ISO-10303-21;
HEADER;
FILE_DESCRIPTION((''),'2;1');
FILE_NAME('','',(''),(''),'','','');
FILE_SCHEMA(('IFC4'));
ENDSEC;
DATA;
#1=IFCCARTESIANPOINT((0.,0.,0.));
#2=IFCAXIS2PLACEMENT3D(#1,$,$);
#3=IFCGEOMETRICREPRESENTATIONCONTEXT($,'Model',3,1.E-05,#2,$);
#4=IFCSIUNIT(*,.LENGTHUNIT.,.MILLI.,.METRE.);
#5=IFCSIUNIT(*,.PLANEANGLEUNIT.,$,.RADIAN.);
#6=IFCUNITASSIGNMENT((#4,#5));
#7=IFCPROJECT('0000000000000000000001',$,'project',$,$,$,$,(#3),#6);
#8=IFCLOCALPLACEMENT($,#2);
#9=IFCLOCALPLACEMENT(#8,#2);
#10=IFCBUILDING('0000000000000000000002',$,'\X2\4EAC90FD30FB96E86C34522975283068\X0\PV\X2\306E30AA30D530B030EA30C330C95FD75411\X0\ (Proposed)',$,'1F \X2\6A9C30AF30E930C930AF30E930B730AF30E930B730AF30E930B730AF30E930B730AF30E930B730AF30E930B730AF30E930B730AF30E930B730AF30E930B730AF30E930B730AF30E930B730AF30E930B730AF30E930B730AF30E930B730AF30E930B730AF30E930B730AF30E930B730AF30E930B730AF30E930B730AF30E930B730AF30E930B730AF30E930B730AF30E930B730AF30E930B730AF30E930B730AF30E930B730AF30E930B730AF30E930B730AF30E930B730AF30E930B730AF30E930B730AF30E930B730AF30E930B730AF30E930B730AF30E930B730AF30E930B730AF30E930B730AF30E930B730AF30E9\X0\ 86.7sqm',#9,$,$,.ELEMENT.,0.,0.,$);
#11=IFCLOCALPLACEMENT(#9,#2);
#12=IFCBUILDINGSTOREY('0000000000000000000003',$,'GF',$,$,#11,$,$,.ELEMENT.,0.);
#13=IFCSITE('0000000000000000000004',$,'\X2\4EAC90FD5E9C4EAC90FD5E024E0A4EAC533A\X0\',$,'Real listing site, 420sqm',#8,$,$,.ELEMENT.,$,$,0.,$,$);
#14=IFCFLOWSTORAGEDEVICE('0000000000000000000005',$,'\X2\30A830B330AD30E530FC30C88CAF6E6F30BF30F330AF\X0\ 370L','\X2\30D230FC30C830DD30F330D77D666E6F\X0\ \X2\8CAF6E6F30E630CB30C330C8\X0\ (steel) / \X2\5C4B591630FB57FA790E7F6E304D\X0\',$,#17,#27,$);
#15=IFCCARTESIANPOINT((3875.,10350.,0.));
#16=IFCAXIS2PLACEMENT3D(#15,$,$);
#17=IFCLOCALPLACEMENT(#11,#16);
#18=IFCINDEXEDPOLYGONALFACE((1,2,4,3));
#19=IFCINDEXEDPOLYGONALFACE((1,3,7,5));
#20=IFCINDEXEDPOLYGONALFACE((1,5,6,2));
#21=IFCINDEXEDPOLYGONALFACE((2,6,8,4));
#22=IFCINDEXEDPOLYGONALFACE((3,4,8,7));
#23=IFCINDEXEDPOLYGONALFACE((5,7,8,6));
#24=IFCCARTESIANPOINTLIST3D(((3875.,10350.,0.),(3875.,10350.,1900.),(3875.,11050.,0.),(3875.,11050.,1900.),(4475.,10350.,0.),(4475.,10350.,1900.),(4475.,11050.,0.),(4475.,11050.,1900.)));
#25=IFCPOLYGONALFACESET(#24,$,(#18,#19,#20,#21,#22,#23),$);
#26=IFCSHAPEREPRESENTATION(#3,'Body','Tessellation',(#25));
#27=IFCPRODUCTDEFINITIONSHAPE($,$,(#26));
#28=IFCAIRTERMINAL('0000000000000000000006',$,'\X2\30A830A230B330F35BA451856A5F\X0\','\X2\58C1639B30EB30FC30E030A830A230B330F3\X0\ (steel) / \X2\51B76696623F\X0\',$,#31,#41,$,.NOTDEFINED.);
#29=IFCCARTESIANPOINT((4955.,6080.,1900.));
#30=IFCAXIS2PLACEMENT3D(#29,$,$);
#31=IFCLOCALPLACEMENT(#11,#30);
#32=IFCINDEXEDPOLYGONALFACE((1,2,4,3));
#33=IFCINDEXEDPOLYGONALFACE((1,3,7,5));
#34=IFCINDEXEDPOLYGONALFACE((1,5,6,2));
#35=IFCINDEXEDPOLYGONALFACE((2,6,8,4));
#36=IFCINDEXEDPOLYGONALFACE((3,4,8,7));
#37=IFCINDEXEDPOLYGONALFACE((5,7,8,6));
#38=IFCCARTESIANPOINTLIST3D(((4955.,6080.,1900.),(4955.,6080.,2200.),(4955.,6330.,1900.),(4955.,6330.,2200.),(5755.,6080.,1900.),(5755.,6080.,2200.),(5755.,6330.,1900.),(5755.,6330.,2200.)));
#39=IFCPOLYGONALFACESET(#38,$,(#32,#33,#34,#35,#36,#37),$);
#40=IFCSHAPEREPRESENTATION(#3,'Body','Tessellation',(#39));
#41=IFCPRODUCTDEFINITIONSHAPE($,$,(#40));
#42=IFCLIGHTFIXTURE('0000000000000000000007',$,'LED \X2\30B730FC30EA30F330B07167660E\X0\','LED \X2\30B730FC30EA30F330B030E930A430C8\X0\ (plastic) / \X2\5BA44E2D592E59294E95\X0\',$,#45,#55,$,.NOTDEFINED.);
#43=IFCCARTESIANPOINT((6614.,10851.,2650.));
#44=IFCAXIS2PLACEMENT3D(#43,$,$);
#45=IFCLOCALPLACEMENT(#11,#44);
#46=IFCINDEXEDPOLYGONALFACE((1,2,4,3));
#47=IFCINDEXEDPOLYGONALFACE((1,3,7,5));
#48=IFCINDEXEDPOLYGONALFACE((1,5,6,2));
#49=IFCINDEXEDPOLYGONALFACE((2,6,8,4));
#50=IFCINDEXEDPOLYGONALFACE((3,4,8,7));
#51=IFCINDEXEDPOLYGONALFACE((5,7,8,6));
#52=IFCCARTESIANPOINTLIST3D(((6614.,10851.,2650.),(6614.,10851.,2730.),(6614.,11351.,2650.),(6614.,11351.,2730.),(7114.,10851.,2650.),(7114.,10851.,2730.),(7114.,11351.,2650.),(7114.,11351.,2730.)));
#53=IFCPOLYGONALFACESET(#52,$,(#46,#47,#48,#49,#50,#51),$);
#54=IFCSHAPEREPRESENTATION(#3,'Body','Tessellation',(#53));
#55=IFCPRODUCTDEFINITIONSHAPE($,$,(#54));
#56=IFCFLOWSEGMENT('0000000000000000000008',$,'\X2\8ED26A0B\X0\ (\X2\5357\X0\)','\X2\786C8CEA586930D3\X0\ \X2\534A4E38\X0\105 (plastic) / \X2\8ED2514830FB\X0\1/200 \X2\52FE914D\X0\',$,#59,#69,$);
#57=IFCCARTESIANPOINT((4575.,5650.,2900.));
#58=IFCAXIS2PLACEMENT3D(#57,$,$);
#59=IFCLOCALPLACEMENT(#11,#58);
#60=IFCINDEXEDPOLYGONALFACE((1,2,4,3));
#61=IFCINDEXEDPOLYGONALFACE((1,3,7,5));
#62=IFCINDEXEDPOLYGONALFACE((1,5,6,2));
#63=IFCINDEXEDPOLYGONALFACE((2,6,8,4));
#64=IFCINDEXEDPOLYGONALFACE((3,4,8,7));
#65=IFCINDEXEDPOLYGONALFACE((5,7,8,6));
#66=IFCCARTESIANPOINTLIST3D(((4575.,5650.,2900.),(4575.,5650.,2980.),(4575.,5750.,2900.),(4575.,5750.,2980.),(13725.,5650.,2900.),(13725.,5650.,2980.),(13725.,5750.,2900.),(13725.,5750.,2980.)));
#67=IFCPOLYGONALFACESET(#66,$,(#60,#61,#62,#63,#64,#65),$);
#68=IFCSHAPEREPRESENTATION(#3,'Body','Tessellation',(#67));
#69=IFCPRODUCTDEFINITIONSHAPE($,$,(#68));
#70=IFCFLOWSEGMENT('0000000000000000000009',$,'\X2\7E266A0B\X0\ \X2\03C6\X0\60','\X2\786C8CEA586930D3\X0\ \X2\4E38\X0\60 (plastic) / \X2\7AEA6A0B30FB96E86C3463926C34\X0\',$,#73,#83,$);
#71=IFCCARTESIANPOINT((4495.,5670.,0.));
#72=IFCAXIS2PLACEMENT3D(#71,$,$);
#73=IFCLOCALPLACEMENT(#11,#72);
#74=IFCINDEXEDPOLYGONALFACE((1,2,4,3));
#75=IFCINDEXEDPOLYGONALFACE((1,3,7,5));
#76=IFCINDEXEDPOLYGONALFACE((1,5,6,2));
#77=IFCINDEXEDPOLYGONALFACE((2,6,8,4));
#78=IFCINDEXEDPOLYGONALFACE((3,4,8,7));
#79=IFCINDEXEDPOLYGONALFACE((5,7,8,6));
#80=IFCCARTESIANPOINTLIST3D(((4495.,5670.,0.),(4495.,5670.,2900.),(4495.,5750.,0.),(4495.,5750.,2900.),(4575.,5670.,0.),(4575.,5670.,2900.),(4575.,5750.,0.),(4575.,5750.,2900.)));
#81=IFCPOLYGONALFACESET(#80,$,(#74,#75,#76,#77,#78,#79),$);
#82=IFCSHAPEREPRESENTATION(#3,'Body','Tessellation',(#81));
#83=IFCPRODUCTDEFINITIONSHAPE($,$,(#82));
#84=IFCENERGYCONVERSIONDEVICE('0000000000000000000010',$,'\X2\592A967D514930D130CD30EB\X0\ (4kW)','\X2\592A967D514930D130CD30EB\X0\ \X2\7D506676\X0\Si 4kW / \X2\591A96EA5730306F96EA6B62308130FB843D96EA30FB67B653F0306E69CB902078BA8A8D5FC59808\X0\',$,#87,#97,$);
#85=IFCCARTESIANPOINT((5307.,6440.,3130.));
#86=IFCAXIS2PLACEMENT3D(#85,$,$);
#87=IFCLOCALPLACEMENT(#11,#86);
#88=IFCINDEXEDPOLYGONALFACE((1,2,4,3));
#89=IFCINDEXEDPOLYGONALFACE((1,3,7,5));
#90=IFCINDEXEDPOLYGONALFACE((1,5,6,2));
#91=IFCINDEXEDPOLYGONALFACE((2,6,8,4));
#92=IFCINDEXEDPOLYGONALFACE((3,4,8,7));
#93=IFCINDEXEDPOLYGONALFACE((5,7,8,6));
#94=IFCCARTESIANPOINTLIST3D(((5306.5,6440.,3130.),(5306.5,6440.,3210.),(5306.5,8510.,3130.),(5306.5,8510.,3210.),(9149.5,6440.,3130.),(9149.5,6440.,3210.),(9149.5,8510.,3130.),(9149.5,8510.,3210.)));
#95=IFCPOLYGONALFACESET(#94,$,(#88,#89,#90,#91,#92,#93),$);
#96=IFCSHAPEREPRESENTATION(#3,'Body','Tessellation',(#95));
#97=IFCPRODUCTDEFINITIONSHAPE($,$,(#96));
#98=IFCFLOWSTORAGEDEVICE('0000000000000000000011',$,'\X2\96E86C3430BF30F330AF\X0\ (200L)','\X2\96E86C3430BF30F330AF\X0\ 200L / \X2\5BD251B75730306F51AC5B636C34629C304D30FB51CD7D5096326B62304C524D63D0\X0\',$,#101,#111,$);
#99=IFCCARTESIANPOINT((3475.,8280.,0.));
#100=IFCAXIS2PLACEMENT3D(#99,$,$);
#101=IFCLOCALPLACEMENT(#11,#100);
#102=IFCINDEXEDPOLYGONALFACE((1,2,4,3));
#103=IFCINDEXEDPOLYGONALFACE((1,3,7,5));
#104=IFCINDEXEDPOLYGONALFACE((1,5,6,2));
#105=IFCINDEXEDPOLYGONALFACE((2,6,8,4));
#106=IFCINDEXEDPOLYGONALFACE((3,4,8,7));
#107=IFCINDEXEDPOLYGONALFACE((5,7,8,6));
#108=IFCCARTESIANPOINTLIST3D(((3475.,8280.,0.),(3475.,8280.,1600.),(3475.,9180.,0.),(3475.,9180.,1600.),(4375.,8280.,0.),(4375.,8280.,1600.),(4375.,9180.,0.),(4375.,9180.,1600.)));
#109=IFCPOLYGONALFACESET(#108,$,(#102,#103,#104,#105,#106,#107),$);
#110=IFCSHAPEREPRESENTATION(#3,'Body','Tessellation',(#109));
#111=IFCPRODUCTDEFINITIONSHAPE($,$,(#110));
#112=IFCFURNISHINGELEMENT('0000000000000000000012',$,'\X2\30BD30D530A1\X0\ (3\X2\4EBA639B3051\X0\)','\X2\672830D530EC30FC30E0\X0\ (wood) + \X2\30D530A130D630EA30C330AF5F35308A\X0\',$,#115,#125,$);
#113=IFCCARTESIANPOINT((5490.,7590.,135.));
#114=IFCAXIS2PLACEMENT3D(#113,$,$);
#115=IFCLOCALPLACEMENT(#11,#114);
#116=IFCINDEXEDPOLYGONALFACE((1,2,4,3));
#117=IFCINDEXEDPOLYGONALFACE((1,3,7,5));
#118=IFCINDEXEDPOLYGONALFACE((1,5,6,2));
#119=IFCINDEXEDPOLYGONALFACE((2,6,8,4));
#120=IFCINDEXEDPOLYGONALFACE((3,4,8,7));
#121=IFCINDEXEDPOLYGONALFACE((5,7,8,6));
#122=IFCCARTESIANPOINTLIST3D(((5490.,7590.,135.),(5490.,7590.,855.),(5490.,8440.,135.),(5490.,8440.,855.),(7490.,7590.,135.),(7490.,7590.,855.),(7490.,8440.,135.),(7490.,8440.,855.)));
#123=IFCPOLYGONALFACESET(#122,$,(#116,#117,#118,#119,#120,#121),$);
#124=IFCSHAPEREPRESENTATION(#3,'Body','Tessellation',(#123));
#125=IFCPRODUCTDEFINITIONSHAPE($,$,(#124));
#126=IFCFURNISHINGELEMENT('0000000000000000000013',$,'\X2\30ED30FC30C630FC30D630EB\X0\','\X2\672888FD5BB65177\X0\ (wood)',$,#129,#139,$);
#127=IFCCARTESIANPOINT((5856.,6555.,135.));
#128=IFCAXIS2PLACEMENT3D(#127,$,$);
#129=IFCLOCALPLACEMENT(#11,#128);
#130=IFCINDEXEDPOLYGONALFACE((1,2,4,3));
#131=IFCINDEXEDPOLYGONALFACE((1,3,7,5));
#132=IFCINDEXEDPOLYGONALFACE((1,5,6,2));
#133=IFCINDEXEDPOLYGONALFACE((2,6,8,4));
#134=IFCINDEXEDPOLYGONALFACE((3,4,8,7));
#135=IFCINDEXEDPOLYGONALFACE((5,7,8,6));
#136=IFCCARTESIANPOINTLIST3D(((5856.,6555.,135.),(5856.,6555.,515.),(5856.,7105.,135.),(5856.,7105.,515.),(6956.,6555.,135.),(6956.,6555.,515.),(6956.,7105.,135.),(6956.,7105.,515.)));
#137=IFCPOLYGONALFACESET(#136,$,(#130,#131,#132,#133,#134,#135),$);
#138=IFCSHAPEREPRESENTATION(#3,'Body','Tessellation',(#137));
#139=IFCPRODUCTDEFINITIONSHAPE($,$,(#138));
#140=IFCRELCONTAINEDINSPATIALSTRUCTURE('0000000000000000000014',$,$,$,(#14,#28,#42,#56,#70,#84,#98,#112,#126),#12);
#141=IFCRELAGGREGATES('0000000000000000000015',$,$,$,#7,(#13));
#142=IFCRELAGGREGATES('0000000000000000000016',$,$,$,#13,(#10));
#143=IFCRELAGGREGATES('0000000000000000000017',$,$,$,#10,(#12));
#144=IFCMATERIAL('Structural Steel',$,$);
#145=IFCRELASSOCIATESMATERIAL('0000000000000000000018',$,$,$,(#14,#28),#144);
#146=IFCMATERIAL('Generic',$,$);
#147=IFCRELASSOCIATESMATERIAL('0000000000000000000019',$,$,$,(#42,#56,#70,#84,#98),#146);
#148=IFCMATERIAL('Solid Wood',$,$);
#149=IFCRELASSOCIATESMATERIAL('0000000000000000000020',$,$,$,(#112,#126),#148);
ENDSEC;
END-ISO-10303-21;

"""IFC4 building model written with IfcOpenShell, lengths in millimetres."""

from ifc_helpers import new_model, si_unit, frame, frame_2d, origin, place, context, project, spatial, rectangle, extrude, material, element, save


model = new_model("IFC4")

# Units and contexts
model_context = context("Model", 3, precision=1e-05, world=origin())
ifc_project = project(units=[si_unit("LENGTHUNIT", "METRE", prefix="MILLI"), si_unit("PLANEANGLEUNIT", "RADIAN")], contexts=[model_context])

# Site, building, storey
site_placement = place(None, origin())
site = spatial("IfcSite", under=ifc_project, at=site_placement, Name="京都府京都市上京区", ObjectType="Real listing site, 420sqm", CompositionType="ELEMENT", RefElevation=0.0)
building_placement = place(site_placement, origin())
building = spatial("IfcBuilding", under=site, at=building_placement, Name="京都・雨水利用とPVのオフグリッド志向 (Proposed)", ObjectType="1F 檜クラドクラシクラシクラシクラシクラシクラシクラシクラシクラシクラシクラシクラシクラシクラシクラシクラシクラシクラシクラシクラシクラシクラシクラシクラシクラシクラシクラシクラシクラシクラシクラシクラシクラシクラシクラシクラシクラシクラシクラ 86.7sqm", CompositionType="ELEMENT", ElevationOfRefHeight=0.0, ElevationOfTerrain=0.0)
storey_placement = place(building_placement, origin())
storey = spatial("IfcBuildingStorey", under=building, at=storey_placement, Name="GF", CompositionType="ELEMENT", Elevation=0.0)

# Shared definitions
ifc_material_1 = material(Name="Solid Wood")

# Shared definitions
ifc_material_2 = material(Name="Structural Steel")

# Shared definitions
ifc_material_3 = material(Name="Generic")

# Flow storage device
flow_storage_device_1_placement = place(storey_placement, frame((3875.0, 10350.0, 0.0)))
element("IfcFlowStorageDevice", 1, at=flow_storage_device_1_placement, inside=storey, material=ifc_material_2, Name="エコキュート貯湯タンク 370L", Description="ヒートポンプ給湯 貯湯ユニット (steel) / 屋外・基礎置き", context=model_context, shape_type="SweptSolid", body=[
    extrude(rectangle(XDim=600.0, YDim=700.0, at=frame_2d((300.0, 350.0))), frame((3875.0, 10350.0, 0.0)), (0.0, 0.0, 1.0), 1900.0),
])

# Air terminal
air_terminal_placement = place(storey_placement, frame((4955.0, 6080.0, 1900.0)))
element("IfcAirTerminal", 2, at=air_terminal_placement, inside=storey, material=ifc_material_2, Name="エアコン室内機", Description="壁掛ルームエアコン (steel) / 冷暖房", PredefinedType="NOTDEFINED", context=model_context, shape_type="SweptSolid", body=[
    extrude(rectangle(XDim=800.0, YDim=250.0, at=frame_2d((400.0, 125.0))), frame((4955.0, 6080.0, 1900.0)), (0.0, 0.0, 1.0), 300.0),
])

# Light fixture
light_fixture_placement = place(storey_placement, frame((6614.0, 10851.0, 2650.0)))
element("IfcLightFixture", 3, at=light_fixture_placement, inside=storey, material=ifc_material_3, Name="LED シーリング照明", Description="LED シーリングライト (plastic) / 室中央天井", PredefinedType="NOTDEFINED", context=model_context, shape_type="SweptSolid", body=[
    extrude(rectangle(XDim=500.0, YDim=500.0, at=frame_2d((250.0, 250.0))), frame((6614.0, 10851.0, 2650.0)), (0.0, 0.0, 1.0), 80.0),
])

# Flow segments
flow_segment_1_placement = place(storey_placement, frame((4575.0, 5650.0, 2900.0)))
element("IfcFlowSegment", 4, at=flow_segment_1_placement, inside=storey, material=ifc_material_3, Name="軒樋 (南)", Description="硬質塩ビ 半丸105 (plastic) / 軒先・1/200 勾配", context=model_context, shape_type="SweptSolid", body=[
    extrude(rectangle(XDim=9150.0, YDim=100.0, at=frame_2d((4575.0, 50.0))), frame((4575.0, 5650.0, 2900.0)), (0.0, 0.0, 1.0), 80.0),
])
flow_segment_2_placement = place(storey_placement, frame((4495.0, 5670.0, 0.0)))
element("IfcFlowSegment", 5, at=flow_segment_2_placement, inside=storey, material=ifc_material_3, Name="縦樋 φ60", Description="硬質塩ビ 丸60 (plastic) / 竪樋・雨水排水", context=model_context, shape_type="SweptSolid", body=[
    extrude(rectangle(XDim=80.0, YDim=80.0, at=frame_2d((40.0, 40.0))), frame((4495.0, 5670.0, 0.0)), (0.0, 0.0, 1.0), 2900.0),
])

# Energy conversion device
energy_conversion_device_placement = place(storey_placement, frame((5307.0, 6440.0, 3130.0)))
element("IfcEnergyConversionDevice", 6, at=energy_conversion_device_placement, inside=storey, material=ifc_material_3, Name="太陽光パネル (4kW)", Description="太陽光パネル 結晶Si 4kW / 多雪地は雪止め・落雪・架台の構造確認必須", context=model_context, shape_type="SweptSolid", body=[
    extrude(rectangle(XDim=3843.0, YDim=2070.0, at=frame_2d((1921.0, 1035.0))), frame((5307.0, 6440.0, 3130.0)), (0.0, 0.0, 1.0), 80.0),
])

# Flow storage device
flow_storage_device_2_placement = place(storey_placement, frame((3475.0, 8280.0, 0.0)))
element("IfcFlowStorageDevice", 7, at=flow_storage_device_2_placement, inside=storey, material=ifc_material_3, Name="雨水タンク (200L)", Description="雨水タンク 200L / 寒冷地は冬季水抜き・凍結防止が前提", context=model_context, shape_type="SweptSolid", body=[
    extrude(rectangle(XDim=900.0, YDim=900.0, at=frame_2d((450.0, 450.0))), frame((3475.0, 8280.0, 0.0)), (0.0, 0.0, 1.0), 1600.0),
])

# Furnishing elements
furnishing_1_placement = place(storey_placement, frame((5490.0, 7590.0, 135.0)))
element("IfcFurnishingElement", 8, at=furnishing_1_placement, inside=storey, material=ifc_material_1, Name="ソファ (3人掛け)", Description="木フレーム (wood) + ファブリック張り", context=model_context, shape_type="SweptSolid", body=[
    extrude(rectangle(XDim=2000.0, YDim=850.0, at=frame_2d((1000.0, 425.0))), frame((5490.0, 7590.0, 135.0)), (0.0, 0.0, 1.0), 720.0),
])
furnishing_2_placement = place(storey_placement, frame((5856.0, 6555.0, 135.0)))
element("IfcFurnishingElement", 9, at=furnishing_2_placement, inside=storey, material=ifc_material_1, Name="ローテーブル", Description="木製家具 (wood)", context=model_context, shape_type="SweptSolid", body=[
    extrude(rectangle(XDim=1100.0, YDim=550.0, at=frame_2d((550.0, 275.0))), frame((5856.0, 6555.0, 135.0)), (0.0, 0.0, 1.0), 380.0),
])

save(model, "model.ifc")
